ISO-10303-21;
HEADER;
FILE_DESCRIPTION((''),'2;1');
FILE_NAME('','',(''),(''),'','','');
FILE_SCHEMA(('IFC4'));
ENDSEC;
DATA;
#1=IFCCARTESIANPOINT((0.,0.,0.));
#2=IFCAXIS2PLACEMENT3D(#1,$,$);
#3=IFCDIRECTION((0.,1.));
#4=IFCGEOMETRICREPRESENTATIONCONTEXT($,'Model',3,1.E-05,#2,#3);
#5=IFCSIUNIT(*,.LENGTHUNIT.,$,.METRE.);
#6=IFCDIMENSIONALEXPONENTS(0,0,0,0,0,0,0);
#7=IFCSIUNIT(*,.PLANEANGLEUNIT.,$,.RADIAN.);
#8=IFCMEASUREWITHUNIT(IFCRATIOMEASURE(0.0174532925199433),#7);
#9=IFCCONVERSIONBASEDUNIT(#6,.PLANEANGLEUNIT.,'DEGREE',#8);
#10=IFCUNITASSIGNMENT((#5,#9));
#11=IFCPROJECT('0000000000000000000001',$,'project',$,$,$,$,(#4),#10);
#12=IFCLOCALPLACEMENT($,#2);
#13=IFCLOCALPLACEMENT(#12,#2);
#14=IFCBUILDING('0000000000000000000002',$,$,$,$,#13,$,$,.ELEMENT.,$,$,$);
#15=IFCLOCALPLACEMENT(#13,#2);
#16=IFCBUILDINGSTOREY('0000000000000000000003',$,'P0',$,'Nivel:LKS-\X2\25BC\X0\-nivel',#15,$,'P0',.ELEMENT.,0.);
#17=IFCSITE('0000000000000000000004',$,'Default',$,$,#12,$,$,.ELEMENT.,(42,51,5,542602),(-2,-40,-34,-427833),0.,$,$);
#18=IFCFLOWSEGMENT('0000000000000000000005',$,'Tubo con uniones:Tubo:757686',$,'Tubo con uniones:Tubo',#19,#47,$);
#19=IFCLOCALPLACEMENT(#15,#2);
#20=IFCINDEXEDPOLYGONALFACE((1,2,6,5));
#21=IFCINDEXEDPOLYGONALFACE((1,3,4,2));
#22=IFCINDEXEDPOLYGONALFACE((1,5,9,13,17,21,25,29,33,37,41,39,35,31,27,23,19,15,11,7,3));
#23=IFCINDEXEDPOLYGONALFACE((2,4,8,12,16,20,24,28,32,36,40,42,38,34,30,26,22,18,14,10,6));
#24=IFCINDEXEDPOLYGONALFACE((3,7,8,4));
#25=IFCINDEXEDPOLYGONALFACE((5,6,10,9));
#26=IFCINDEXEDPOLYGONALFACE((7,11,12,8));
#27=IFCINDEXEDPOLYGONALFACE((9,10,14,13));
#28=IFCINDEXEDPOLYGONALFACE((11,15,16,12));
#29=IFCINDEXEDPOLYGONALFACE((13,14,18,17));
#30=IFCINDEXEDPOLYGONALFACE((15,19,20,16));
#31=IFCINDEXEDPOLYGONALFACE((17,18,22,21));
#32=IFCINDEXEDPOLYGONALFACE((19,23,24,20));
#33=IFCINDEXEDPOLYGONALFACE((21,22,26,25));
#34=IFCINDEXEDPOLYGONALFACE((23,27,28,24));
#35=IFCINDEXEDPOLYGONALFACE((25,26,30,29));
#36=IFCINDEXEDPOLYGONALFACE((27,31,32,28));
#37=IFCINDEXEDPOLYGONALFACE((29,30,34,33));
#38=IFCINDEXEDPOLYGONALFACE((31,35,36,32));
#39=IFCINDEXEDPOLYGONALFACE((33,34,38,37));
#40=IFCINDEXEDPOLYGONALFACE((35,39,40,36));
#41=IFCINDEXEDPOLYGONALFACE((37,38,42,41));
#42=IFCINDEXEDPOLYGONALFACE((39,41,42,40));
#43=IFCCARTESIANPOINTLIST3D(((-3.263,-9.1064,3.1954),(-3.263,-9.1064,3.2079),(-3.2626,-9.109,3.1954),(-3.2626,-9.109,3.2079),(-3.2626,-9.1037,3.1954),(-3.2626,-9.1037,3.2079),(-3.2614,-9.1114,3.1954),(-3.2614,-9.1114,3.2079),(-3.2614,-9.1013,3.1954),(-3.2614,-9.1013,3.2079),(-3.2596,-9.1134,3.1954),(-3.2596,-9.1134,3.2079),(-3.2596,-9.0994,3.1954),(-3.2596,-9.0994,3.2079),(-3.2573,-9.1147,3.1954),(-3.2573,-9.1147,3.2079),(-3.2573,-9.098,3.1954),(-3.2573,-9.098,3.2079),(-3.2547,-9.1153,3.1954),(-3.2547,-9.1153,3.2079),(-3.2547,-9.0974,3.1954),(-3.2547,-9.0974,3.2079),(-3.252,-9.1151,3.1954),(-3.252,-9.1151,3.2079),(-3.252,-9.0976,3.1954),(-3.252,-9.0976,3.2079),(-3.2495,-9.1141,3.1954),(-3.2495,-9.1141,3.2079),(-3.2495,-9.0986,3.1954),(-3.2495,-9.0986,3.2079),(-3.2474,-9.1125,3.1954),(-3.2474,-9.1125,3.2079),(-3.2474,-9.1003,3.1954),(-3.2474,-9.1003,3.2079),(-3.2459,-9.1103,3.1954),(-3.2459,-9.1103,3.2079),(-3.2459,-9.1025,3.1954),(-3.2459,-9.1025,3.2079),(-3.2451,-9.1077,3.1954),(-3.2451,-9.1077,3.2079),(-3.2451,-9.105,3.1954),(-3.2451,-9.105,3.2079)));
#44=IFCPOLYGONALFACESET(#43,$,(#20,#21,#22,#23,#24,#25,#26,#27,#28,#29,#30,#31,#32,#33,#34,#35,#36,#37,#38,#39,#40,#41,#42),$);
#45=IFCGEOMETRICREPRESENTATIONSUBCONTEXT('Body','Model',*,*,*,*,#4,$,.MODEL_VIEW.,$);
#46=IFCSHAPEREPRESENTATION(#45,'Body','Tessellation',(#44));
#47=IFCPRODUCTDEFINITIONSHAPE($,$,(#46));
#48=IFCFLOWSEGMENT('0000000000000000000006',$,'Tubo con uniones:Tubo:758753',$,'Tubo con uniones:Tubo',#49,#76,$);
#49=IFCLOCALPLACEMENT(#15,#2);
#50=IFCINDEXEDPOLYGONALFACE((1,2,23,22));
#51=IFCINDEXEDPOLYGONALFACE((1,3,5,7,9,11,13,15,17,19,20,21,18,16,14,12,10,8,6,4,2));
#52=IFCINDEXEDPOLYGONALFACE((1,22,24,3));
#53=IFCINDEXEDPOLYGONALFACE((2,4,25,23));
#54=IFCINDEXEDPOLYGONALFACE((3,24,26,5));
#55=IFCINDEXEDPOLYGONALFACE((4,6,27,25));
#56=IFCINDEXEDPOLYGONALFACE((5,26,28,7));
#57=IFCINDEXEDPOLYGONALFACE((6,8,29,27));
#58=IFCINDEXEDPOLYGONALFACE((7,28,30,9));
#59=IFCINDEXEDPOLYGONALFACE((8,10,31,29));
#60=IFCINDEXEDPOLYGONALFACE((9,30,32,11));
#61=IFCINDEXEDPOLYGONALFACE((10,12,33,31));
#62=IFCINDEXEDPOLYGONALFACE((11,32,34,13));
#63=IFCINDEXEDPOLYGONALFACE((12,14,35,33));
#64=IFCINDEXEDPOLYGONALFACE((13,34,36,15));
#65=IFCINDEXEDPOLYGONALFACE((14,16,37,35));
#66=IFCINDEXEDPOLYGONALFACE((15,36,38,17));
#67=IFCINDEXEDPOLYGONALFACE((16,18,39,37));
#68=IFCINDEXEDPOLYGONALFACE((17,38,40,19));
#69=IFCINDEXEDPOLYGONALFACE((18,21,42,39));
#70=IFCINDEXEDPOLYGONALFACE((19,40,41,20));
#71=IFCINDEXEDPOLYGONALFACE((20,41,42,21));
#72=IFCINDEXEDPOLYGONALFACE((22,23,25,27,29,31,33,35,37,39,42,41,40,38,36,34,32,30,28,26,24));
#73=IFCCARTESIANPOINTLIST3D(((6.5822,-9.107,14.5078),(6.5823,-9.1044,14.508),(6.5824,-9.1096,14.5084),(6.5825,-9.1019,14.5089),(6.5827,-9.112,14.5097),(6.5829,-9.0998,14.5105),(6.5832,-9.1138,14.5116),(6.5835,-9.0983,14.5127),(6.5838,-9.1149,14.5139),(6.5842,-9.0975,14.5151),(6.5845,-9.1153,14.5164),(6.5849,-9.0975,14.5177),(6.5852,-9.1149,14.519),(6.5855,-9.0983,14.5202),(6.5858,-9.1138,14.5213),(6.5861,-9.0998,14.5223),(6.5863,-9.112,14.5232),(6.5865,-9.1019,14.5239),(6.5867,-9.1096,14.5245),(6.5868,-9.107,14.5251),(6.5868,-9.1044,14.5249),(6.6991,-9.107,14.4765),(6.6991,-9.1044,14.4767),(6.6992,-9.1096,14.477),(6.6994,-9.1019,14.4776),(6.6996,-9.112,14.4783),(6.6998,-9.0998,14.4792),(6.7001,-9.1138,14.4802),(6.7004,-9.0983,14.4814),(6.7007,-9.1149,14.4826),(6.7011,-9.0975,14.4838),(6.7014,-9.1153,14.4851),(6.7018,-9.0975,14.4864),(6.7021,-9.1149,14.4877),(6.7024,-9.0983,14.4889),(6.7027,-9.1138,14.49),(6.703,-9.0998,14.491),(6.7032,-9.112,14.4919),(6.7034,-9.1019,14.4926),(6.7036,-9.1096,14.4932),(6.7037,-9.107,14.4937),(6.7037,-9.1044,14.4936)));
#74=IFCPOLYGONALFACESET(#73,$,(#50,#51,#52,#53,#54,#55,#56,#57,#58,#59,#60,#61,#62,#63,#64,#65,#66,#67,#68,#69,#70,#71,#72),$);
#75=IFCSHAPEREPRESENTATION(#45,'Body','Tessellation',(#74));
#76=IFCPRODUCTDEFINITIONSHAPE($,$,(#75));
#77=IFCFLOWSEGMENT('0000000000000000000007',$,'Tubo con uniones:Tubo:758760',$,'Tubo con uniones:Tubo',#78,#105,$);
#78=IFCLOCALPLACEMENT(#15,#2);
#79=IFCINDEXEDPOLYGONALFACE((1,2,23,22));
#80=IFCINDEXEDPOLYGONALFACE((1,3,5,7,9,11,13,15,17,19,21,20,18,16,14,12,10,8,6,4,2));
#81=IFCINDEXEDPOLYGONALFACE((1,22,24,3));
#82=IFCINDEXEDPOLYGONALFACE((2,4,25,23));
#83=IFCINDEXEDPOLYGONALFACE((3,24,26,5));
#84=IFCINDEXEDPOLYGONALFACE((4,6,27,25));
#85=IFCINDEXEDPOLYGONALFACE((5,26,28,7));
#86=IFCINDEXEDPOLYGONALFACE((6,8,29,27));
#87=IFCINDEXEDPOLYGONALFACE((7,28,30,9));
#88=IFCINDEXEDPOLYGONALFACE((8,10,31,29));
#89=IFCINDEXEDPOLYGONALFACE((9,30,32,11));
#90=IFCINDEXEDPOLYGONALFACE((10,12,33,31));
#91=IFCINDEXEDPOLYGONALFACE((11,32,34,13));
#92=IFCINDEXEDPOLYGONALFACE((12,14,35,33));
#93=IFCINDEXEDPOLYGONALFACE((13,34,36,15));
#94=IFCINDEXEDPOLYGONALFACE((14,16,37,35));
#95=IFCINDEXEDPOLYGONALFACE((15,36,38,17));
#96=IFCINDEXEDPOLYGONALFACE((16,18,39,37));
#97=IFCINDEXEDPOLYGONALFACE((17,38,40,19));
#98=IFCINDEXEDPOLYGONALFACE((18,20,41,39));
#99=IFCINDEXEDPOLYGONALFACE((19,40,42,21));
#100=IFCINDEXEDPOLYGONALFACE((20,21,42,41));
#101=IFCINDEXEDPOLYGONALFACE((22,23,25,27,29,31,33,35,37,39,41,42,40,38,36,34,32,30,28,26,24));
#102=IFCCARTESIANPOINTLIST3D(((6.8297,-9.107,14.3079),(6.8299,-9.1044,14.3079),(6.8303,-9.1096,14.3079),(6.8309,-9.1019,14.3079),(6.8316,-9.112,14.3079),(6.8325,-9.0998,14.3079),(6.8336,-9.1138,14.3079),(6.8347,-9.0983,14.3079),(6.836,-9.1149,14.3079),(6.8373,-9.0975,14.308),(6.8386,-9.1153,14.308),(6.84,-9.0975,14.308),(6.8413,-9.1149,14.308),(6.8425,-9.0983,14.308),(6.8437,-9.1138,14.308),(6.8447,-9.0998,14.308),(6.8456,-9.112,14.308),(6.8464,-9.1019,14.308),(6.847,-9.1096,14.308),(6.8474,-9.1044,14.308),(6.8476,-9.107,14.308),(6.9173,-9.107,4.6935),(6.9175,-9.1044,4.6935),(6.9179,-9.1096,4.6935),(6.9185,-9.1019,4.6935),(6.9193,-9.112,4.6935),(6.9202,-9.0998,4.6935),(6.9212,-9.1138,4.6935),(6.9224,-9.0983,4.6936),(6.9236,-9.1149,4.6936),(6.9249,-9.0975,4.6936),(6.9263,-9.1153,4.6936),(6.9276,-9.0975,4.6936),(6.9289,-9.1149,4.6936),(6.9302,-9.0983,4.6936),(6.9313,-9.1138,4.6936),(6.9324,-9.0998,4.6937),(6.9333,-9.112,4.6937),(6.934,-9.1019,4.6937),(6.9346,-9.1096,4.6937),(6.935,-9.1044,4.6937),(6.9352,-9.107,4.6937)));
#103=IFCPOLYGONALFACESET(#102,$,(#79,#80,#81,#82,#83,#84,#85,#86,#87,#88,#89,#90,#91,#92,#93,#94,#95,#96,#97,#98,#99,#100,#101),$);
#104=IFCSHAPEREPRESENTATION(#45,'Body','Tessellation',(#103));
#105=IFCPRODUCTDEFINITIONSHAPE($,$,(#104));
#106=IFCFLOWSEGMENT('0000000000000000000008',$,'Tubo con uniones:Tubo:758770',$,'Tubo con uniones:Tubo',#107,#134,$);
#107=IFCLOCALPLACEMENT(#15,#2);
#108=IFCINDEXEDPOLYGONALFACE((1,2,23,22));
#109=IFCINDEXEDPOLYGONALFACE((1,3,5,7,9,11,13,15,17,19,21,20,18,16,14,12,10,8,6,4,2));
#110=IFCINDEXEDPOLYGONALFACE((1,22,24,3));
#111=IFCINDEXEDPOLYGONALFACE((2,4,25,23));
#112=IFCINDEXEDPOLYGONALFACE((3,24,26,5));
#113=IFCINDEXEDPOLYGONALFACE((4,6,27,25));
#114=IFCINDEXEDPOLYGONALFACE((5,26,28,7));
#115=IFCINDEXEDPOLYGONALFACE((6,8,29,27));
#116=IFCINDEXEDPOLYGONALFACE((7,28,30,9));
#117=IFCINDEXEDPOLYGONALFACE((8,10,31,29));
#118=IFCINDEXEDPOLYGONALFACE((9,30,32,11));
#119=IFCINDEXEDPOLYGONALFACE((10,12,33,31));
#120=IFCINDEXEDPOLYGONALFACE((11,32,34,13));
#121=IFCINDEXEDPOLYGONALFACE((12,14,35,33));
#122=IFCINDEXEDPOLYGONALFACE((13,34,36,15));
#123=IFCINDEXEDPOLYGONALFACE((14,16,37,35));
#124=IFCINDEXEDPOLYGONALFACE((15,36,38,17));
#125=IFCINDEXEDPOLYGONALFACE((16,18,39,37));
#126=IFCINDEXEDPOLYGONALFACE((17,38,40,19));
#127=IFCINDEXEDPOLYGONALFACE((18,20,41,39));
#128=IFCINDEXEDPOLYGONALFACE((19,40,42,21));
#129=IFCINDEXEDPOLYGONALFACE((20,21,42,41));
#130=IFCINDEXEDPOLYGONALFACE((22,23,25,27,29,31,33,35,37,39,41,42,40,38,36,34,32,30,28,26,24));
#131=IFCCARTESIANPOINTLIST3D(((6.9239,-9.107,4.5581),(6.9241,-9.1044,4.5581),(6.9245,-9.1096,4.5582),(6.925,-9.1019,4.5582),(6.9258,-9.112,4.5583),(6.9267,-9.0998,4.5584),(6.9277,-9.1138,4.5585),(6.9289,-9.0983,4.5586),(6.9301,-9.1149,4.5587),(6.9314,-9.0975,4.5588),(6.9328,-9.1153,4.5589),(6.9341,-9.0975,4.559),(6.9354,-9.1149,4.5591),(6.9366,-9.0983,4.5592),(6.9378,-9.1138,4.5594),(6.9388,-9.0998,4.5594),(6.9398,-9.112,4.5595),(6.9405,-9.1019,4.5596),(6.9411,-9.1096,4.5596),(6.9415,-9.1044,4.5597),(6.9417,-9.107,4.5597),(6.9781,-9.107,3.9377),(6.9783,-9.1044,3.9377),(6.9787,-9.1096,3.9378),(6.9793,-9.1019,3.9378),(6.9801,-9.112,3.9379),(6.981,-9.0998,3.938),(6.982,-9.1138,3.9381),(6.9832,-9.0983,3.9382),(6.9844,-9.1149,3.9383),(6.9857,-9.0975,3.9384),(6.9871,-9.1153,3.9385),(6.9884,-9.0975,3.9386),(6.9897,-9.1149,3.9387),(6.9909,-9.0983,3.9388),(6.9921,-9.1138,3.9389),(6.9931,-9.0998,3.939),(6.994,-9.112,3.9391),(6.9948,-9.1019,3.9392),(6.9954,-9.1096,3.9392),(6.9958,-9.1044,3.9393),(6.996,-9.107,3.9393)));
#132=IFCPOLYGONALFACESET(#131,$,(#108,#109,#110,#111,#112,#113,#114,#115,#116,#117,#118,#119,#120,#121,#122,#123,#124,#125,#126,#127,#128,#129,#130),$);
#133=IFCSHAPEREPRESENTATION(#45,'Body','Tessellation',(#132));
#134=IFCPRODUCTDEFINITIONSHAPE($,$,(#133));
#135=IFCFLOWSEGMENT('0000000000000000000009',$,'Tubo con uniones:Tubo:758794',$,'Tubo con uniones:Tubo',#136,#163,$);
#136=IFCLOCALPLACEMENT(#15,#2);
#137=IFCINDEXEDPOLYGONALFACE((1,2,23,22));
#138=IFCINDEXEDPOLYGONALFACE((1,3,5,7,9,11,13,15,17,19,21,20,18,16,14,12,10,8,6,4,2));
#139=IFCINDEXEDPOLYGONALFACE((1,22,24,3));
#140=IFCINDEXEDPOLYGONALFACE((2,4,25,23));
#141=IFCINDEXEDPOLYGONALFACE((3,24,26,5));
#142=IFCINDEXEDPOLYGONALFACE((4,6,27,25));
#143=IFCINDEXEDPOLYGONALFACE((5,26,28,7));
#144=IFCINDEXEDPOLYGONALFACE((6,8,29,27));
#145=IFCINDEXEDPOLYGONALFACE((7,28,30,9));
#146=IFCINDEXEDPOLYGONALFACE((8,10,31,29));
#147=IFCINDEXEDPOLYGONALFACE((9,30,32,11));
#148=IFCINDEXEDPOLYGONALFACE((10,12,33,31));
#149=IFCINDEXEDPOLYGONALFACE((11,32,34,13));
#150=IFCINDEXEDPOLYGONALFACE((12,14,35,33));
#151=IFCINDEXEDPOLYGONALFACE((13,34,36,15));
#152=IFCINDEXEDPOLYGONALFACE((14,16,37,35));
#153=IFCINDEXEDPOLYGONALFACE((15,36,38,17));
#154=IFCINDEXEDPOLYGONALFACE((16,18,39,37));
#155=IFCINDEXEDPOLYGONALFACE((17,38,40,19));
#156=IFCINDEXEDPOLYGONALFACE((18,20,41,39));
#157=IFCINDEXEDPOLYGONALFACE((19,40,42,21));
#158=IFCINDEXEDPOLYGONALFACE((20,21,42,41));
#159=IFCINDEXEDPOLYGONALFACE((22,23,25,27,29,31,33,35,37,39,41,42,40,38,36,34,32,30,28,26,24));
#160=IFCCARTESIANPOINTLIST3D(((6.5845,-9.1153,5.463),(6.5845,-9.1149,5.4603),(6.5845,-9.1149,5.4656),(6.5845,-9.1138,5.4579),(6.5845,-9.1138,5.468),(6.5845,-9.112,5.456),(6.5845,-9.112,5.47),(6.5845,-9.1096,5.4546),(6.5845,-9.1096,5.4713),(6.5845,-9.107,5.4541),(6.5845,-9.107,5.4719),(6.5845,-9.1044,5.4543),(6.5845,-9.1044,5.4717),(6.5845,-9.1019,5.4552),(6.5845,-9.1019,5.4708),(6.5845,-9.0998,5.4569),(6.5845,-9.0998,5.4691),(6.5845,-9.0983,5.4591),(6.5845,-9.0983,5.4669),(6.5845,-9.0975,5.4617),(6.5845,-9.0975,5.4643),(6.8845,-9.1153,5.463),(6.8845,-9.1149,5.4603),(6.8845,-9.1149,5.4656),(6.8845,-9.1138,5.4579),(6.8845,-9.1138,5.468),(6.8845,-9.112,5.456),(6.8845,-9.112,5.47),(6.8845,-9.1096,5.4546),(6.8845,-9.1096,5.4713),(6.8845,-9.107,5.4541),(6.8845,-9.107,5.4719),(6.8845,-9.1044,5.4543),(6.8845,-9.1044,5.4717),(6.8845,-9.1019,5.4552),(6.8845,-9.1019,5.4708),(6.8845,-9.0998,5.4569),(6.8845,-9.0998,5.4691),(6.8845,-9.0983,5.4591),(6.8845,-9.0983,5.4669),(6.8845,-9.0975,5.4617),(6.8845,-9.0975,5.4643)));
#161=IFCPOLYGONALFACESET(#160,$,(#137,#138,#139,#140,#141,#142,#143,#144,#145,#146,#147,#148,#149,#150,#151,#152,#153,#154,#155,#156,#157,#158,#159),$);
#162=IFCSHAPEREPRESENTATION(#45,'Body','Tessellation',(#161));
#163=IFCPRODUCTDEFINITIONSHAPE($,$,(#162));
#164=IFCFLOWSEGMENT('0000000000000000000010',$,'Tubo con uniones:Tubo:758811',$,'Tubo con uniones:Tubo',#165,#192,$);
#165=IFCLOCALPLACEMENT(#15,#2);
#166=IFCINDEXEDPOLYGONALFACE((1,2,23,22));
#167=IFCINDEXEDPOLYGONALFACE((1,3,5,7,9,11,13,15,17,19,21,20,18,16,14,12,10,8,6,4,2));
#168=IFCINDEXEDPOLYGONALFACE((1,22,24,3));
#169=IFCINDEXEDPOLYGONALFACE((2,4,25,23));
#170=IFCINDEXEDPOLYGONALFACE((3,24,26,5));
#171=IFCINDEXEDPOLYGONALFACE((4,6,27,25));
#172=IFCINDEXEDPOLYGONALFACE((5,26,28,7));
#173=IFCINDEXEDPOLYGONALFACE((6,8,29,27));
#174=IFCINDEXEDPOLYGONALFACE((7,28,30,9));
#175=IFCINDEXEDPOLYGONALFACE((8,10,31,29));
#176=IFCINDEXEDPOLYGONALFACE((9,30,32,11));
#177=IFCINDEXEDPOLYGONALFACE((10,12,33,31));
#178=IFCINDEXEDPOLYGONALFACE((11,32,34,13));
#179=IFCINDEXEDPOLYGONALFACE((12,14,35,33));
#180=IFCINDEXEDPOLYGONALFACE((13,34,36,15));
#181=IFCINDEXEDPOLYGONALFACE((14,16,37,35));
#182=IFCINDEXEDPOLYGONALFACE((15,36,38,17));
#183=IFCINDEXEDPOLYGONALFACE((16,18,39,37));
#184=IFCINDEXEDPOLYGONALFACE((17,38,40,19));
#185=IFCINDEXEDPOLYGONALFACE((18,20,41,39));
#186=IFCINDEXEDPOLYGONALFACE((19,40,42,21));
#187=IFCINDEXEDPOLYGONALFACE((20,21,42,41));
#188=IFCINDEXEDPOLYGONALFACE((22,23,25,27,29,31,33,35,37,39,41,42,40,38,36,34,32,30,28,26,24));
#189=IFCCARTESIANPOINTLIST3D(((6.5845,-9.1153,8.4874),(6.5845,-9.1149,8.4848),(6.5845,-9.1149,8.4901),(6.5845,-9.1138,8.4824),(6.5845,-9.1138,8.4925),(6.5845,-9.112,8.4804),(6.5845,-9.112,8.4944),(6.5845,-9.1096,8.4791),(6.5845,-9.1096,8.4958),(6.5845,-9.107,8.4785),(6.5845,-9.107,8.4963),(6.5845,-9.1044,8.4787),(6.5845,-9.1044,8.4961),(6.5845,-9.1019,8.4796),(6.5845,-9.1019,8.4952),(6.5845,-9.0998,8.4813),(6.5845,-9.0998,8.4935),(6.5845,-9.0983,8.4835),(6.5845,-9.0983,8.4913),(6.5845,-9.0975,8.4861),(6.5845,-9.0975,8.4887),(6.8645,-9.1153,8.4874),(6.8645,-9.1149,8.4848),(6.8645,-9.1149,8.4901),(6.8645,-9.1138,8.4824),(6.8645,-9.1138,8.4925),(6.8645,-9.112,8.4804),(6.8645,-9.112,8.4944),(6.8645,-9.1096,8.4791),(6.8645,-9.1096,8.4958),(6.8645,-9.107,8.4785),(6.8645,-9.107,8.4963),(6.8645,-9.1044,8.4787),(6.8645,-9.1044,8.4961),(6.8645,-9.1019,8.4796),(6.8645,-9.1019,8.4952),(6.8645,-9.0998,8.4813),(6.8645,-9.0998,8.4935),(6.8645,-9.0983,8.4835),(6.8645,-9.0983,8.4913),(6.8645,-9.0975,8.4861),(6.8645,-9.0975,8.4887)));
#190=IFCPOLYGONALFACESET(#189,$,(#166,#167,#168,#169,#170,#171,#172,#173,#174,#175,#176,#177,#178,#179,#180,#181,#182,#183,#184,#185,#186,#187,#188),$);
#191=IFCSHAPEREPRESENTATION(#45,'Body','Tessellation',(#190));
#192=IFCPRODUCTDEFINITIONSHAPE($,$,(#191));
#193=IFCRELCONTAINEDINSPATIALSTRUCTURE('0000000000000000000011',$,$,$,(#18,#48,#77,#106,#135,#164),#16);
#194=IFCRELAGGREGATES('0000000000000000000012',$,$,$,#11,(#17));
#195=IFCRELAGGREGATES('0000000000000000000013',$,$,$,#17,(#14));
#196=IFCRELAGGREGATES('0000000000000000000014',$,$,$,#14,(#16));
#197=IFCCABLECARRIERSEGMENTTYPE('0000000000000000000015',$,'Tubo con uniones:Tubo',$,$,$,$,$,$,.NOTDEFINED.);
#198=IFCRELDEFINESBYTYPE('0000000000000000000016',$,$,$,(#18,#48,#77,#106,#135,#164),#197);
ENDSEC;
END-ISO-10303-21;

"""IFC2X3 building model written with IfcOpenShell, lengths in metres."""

from ifc_helpers import new_model, entity, si_unit, converted_unit, direction, frame, frame_2d, origin, origin_2d_with_axis, place, context, subcontext, project, spatial, circle, extrude, type_object, element, save


model = new_model("IFC2X3")

# Units and contexts
model_context = context("Model", 3, precision=1e-05, world=origin(), true_north=direction((0.0, 1.0)))
body_context = subcontext(model_context, "Body", "Model", "MODEL_VIEW")
ifc_project = project(units=[si_unit("LENGTHUNIT", "METRE"), converted_unit("PLANEANGLEUNIT", "DEGREE", entity("IfcRatioMeasure", 0.0174532925199433), si_unit("PLANEANGLEUNIT", "RADIAN"), dimensions=[0, 0, 0, 0, 0, 0, 0])], contexts=[model_context])

# Site, building, storey
site_placement = place(None, origin())
site = spatial("IfcSite", under=ifc_project, at=site_placement, Name="Default", CompositionType="ELEMENT", RefLatitude=(42, 51, 5, 542602), RefLongitude=(-2, -40, -34, -427833), RefElevation=0.0)
building_placement = place(site_placement, origin())
building = spatial("IfcBuilding", under=site, at=building_placement, CompositionType="ELEMENT")
storey_placement = place(building_placement, origin())
storey = spatial("IfcBuildingStorey", under=building, at=storey_placement, Name="P0", ObjectType="Nivel:LKS-▼-nivel", LongName="P0", CompositionType="ELEMENT", Elevation=0.0)

# Flow segments
cable_carrier_segment_type = type_object("IfcCableCarrierSegmentType", Name="Tubo con uniones:Tubo", PredefinedType="NOTDEFINED")
flow_segment_1_placement = place(storey_placement, origin())
element("IfcFlowSegment", 1, at=flow_segment_1_placement, inside=storey, type_object=cable_carrier_segment_type, Name="Tubo con uniones:Tubo:757686", ObjectType="Tubo con uniones:Tubo", context=body_context, shape_type="SweptSolid", body=[
    extrude(circle(Radius=0.009, at=origin_2d_with_axis()), frame((-3.254, -9.1064, 3.1954), z_axis=(0.0, 0.0, 1.0), x_axis=(-1.0, 0.0, 0.0)), (0.0, 0.0, 1.0), 0.0125),
])
flow_segment_2_placement = place(storey_placement, origin())
element("IfcFlowSegment", 2, at=flow_segment_2_placement, inside=storey, type_object=cable_carrier_segment_type, Name="Tubo con uniones:Tubo:758753", ObjectType="Tubo con uniones:Tubo", context=body_context, shape_type="SweptSolid", body=[
    extrude(circle(Radius=0.009, at=frame_2d((0.0, 0.0), x_axis=(1.0, 0.0))), frame((6.7014, -9.1064, 14.4851), z_axis=(-0.965926, 0.0, 0.258819), x_axis=(0.0, -1.0, 0.0)), (0.0, 0.0, 1.0), 0.121),
])
flow_segment_3_placement = place(storey_placement, origin())
element("IfcFlowSegment", 3, at=flow_segment_3_placement, inside=storey, type_object=cable_carrier_segment_type, Name="Tubo con uniones:Tubo:758760", ObjectType="Tubo con uniones:Tubo", context=body_context, shape_type="SweptSolid", body=[
    extrude(circle(Radius=0.009, at=frame_2d((0.0, 0.0), x_axis=(1.0, 0.0))), frame((6.8386, -9.1064, 14.308), z_axis=(0.009117, 0.0, -0.999958), x_axis=(0.0, -1.0, 0.0)), (0.0, 0.0, 1.0), 9.6148),
])
flow_segment_4_placement = place(storey_placement, origin())
element("IfcFlowSegment", 4, at=flow_segment_4_placement, inside=storey, type_object=cable_carrier_segment_type, Name="Tubo con uniones:Tubo:758770", ObjectType="Tubo con uniones:Tubo", context=body_context, shape_type="SweptSolid", body=[
    extrude(circle(Radius=0.009, at=frame_2d((0.0, 0.0), x_axis=(1.0, 0.0))), frame((6.9871, -9.1064, 3.9385), z_axis=(-0.087156, 0.0, 0.996195), x_axis=(0.0, -1.0, 0.0)), (0.0, 0.0, 1.0), 0.6228),
])
flow_segment_5_placement = place(storey_placement, origin())
element("IfcFlowSegment", 5, at=flow_segment_5_placement, inside=storey, type_object=cable_carrier_segment_type, Name="Tubo con uniones:Tubo:758794", ObjectType="Tubo con uniones:Tubo", context=body_context, shape_type="SweptSolid", body=[
    extrude(circle(Radius=0.009, at=origin_2d_with_axis()), frame((6.5845, -9.1064, 5.463), z_axis=(1.0, 0.0, 0.0), x_axis=(0.0, -1.0, 0.0)), (0.0, 0.0, 1.0), 0.3),
])
flow_segment_6_placement = place(storey_placement, origin())
element("IfcFlowSegment", 6, at=flow_segment_6_placement, inside=storey, type_object=cable_carrier_segment_type, Name="Tubo con uniones:Tubo:758811", ObjectType="Tubo con uniones:Tubo", context=body_context, shape_type="SweptSolid", body=[
    extrude(circle(Radius=0.009, at=origin_2d_with_axis()), frame((6.5845, -9.1064, 8.4874), z_axis=(1.0, 0.0, 0.0), x_axis=(0.0, -1.0, 0.0)), (0.0, 0.0, 1.0), 0.28),
])

save(model, "model.ifc")
